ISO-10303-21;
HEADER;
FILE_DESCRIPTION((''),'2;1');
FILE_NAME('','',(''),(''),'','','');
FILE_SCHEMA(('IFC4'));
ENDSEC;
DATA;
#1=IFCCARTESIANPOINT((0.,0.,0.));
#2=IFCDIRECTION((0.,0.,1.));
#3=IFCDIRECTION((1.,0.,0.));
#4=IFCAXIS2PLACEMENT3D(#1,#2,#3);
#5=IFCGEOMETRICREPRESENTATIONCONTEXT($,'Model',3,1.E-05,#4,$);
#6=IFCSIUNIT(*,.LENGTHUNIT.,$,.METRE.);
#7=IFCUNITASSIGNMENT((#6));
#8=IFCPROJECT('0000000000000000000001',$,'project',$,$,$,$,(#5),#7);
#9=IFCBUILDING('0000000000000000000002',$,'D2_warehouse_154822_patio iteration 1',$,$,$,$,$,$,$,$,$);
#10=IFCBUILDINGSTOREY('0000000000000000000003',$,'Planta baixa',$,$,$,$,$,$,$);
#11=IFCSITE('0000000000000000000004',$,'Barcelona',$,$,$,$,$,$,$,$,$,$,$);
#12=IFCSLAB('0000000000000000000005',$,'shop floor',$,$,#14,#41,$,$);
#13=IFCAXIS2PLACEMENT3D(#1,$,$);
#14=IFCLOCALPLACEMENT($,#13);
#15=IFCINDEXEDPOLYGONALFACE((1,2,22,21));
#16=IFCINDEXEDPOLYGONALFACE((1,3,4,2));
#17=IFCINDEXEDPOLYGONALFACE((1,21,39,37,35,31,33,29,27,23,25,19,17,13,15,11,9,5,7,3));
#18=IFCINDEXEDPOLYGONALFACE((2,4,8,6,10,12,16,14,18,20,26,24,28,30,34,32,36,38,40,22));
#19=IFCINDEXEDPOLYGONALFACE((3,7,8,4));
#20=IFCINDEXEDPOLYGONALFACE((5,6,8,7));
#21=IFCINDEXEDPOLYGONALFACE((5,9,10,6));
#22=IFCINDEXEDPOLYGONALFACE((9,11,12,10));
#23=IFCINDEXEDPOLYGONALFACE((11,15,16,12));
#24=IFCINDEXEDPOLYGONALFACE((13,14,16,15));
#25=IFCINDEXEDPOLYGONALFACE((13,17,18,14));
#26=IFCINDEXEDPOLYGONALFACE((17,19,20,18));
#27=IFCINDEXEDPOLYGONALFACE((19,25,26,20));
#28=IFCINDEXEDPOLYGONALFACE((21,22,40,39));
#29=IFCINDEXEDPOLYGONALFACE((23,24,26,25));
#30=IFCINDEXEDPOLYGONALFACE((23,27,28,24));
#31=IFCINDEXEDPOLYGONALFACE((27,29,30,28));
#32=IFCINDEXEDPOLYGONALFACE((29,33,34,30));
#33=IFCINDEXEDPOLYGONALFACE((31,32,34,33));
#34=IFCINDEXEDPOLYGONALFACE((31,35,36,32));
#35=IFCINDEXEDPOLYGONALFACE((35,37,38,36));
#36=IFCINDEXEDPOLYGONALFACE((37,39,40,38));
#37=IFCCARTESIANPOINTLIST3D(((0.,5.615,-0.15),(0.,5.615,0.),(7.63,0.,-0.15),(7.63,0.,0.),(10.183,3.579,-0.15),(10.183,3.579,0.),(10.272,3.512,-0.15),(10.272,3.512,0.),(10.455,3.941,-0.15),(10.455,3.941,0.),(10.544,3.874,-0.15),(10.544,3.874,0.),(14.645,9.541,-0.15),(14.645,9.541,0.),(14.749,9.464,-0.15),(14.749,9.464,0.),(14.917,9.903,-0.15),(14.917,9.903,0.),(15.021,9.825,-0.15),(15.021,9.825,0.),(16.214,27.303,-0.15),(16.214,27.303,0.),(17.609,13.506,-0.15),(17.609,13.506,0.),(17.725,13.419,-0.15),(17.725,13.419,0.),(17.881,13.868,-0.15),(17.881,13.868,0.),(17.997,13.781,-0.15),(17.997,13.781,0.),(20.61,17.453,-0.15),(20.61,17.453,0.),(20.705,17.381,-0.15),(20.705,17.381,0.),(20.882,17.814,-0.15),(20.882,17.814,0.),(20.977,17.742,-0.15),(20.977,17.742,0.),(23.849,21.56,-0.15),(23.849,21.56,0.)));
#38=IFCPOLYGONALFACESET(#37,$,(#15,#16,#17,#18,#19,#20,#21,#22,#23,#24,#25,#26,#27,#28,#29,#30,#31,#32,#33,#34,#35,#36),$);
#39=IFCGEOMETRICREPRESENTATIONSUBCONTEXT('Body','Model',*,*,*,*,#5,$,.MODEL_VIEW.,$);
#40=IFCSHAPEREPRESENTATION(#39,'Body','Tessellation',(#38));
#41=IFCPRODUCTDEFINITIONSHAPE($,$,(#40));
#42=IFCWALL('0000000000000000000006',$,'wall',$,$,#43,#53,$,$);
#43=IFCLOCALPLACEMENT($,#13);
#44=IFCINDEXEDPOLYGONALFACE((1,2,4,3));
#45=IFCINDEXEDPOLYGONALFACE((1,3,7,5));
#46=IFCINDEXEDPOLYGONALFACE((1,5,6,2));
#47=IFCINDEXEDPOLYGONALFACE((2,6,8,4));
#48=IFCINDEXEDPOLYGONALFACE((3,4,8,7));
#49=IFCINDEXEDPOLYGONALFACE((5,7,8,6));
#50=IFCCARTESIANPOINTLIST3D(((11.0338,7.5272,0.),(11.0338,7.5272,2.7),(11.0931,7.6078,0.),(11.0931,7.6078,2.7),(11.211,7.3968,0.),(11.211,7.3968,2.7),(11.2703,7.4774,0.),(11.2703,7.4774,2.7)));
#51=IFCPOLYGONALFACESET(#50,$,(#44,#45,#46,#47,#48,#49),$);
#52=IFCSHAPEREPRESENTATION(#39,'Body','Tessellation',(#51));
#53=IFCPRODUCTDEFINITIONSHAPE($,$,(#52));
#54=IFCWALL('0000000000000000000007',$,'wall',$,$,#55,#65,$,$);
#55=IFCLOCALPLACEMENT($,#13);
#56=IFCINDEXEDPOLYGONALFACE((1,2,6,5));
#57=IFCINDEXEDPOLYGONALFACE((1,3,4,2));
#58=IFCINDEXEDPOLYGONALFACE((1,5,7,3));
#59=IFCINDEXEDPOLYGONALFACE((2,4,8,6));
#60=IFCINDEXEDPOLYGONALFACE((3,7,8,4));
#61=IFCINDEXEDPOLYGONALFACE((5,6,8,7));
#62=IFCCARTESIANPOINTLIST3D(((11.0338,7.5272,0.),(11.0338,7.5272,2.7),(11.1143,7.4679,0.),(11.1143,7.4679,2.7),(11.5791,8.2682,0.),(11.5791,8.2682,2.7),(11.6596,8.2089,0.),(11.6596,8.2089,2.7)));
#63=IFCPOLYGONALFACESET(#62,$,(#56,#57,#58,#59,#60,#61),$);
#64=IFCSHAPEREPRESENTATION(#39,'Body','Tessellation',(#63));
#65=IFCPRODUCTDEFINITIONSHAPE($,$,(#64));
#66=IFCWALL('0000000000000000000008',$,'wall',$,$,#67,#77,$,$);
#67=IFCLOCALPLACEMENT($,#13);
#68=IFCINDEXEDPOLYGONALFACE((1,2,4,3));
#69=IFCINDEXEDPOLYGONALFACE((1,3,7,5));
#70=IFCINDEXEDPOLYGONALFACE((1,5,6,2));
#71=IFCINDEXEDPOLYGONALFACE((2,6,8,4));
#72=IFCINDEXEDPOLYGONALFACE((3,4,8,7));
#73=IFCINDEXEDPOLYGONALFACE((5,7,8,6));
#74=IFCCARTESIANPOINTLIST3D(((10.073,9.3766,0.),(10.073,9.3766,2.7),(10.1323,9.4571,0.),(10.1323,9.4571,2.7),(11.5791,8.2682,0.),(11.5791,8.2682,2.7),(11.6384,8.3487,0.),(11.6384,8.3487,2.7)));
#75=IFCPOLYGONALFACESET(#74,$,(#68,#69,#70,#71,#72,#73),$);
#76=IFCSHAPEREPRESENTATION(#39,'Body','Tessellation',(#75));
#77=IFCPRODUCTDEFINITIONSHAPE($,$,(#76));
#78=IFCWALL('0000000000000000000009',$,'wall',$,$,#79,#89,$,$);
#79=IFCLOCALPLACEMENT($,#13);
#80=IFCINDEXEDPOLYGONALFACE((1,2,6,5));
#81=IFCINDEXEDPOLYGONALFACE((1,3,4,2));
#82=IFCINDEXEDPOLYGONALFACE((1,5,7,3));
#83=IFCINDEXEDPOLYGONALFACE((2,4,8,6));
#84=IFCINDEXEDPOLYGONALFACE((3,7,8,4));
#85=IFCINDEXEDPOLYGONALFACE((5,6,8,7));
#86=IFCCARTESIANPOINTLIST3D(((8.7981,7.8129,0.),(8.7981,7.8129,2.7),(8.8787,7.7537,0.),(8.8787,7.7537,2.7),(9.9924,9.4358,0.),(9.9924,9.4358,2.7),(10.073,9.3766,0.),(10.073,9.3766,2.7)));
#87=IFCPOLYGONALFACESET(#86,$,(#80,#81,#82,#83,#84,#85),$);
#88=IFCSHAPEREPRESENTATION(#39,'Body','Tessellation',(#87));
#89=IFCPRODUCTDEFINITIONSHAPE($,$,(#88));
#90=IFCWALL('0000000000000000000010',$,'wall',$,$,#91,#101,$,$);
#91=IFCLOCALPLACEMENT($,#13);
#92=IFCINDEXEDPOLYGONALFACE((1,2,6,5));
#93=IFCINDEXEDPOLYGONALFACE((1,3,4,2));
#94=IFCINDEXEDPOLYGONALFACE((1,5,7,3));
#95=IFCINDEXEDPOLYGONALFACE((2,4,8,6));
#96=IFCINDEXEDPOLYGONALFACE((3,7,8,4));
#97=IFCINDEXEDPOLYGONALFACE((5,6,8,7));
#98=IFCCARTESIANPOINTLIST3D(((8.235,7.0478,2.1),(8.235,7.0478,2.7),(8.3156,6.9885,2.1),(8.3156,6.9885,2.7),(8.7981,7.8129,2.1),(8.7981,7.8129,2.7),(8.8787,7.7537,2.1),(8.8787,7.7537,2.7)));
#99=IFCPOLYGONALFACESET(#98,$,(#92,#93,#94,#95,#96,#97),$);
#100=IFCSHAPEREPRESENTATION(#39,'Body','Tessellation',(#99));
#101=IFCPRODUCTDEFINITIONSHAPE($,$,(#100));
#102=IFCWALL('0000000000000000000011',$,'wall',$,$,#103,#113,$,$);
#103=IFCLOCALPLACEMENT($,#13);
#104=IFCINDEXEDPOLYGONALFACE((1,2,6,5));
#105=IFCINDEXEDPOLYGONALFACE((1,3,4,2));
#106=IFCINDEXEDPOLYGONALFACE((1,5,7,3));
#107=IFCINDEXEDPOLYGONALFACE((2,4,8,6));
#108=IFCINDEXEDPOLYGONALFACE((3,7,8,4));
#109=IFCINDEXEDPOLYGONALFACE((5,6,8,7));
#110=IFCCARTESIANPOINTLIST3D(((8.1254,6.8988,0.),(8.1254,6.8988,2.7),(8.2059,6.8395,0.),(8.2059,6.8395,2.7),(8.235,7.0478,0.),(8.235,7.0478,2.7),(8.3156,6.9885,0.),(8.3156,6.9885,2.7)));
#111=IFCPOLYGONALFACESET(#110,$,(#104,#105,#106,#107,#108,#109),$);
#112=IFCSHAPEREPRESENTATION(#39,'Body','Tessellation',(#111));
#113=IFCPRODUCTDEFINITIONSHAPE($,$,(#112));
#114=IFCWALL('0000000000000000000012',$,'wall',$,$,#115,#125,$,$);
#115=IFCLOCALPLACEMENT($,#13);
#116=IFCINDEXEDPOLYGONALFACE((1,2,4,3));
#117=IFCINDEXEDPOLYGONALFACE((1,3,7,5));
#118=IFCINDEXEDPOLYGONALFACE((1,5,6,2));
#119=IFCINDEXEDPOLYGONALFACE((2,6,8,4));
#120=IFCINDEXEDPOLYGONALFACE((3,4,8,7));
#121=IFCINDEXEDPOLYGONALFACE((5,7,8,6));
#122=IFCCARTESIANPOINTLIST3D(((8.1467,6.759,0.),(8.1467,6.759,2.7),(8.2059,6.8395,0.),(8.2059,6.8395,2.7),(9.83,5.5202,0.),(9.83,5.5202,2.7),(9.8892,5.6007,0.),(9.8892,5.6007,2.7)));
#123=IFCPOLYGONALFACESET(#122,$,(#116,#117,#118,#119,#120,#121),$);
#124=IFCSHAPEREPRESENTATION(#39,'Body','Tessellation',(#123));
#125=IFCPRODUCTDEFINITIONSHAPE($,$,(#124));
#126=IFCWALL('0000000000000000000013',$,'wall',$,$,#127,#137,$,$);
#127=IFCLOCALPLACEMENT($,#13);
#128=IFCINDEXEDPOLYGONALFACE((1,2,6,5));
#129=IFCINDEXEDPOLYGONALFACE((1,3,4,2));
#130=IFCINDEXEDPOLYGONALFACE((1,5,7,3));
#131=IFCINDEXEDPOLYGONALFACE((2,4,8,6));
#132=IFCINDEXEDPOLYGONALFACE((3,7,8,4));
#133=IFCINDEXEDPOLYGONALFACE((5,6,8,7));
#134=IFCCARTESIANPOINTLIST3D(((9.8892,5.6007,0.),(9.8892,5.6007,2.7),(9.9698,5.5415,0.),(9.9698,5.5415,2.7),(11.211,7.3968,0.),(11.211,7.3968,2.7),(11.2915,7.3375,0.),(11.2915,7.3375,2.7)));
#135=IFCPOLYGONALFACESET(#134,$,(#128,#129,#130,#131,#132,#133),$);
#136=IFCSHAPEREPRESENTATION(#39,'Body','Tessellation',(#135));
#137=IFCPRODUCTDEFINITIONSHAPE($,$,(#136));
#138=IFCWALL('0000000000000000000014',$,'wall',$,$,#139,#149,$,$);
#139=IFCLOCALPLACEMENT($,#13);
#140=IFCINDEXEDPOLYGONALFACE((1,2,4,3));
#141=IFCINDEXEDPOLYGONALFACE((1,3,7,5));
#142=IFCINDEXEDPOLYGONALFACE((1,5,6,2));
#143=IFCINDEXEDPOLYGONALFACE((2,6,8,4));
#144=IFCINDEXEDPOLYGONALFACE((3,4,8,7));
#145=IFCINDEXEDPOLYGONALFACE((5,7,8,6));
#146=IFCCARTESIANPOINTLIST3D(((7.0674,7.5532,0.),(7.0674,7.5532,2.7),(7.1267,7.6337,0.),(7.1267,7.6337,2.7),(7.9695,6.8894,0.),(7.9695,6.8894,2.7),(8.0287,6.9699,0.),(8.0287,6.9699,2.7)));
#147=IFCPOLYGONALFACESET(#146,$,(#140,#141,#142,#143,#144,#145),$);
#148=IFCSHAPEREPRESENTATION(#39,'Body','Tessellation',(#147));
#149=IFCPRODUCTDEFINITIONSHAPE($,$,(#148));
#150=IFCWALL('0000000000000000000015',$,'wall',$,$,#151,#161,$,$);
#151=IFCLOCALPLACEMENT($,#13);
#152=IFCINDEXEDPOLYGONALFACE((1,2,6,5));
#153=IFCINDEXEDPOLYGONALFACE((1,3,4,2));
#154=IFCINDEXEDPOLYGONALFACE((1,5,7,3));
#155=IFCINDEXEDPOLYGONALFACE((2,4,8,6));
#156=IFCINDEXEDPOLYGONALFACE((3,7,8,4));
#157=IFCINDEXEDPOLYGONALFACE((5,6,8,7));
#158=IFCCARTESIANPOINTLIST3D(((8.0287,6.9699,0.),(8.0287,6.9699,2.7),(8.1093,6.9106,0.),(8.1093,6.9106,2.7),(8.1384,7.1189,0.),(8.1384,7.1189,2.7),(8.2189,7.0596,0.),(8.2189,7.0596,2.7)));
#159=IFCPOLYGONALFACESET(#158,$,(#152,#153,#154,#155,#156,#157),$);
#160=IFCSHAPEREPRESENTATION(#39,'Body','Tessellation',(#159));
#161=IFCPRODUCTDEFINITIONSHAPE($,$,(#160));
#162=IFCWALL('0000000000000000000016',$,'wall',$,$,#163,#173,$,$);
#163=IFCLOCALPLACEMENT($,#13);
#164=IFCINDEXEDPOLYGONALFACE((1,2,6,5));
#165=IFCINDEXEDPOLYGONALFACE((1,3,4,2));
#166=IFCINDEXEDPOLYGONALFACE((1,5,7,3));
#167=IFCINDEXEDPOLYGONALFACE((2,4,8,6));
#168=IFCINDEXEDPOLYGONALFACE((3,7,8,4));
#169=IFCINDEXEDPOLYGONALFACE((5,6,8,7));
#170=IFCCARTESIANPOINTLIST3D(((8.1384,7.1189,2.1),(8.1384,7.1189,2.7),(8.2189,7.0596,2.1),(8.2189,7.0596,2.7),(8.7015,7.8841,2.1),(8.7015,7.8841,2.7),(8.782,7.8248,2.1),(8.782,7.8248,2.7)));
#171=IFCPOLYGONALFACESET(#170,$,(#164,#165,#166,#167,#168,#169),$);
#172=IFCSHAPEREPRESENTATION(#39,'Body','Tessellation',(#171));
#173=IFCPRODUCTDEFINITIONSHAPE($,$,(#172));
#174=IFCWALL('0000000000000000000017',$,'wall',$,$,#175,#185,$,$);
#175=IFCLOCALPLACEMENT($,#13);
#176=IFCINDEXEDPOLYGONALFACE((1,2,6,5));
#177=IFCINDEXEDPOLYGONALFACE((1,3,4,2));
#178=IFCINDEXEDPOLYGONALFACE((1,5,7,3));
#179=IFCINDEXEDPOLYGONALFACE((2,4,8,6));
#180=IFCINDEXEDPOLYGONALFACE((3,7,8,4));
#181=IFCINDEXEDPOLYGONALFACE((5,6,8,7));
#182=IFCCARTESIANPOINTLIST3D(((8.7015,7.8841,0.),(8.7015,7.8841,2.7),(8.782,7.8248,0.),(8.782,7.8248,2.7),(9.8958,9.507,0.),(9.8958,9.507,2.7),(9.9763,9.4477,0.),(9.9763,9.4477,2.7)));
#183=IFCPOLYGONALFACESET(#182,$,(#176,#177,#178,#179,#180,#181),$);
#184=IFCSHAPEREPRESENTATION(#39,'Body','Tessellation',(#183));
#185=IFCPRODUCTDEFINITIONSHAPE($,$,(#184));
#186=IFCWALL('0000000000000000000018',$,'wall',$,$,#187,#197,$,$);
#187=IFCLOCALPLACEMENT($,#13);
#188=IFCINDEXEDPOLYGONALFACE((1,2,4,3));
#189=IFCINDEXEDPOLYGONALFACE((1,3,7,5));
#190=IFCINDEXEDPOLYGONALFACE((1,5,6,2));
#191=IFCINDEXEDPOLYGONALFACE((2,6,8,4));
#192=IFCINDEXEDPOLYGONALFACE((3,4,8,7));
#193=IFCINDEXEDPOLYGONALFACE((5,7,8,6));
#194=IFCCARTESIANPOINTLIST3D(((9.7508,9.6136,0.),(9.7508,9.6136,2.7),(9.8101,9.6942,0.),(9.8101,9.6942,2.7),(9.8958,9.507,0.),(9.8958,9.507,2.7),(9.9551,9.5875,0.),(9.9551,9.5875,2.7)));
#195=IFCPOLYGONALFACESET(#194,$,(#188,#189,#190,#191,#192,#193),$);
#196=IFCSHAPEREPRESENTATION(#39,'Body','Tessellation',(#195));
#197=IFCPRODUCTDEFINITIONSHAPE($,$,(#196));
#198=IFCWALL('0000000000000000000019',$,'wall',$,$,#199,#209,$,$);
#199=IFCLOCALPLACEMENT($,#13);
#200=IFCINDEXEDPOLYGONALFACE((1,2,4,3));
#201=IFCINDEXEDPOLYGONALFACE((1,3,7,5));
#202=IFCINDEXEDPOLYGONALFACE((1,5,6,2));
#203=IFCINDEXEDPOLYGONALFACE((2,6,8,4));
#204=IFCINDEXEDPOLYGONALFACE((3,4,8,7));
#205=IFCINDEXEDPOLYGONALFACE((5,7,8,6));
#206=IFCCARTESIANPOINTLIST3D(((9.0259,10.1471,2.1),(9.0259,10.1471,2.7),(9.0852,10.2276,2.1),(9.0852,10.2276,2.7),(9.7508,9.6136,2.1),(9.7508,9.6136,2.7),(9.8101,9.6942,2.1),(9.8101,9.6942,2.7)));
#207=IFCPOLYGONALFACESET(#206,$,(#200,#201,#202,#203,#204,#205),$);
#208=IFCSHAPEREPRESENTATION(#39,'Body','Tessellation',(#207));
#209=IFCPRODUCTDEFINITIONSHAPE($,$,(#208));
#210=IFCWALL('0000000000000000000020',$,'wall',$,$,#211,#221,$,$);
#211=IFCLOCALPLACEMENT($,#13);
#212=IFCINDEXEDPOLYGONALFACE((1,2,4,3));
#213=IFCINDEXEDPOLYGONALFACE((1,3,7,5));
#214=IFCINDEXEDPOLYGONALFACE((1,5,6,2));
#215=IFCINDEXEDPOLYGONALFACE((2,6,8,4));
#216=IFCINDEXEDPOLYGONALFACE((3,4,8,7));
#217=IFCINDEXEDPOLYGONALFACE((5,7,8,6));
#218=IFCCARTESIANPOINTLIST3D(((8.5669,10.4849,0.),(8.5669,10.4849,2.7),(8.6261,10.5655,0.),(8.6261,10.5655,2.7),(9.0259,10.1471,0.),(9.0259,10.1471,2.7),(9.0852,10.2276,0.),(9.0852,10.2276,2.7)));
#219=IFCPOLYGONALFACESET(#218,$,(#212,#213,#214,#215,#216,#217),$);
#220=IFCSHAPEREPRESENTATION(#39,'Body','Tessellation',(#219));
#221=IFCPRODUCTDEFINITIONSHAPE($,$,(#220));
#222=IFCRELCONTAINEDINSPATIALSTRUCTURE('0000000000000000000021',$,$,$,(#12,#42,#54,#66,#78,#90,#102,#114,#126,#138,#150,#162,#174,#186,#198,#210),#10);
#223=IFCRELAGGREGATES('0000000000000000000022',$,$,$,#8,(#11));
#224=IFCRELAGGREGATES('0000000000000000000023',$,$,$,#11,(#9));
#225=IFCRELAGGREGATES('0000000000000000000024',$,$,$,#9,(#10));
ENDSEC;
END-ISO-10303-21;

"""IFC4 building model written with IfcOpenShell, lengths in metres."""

from ifc_helpers import new_model, si_unit, frame, origin, origin_with_axes, place, context, subcontext, project, spatial, polyline, outline, extrude, element, save


model = new_model("IFC4")

# Units and contexts
model_context = context("Model", 3, precision=1e-05, world=origin_with_axes())
body_context = subcontext(model_context, "Body", "Model", "MODEL_VIEW")
ifc_project = project(units=[si_unit("LENGTHUNIT", "METRE")], contexts=[model_context])

# Site, building, storey
site = spatial("IfcSite", under=ifc_project, Name="Barcelona")
building = spatial("IfcBuilding", under=site, Name="D2_warehouse_154822_patio iteration 1")
storey = spatial("IfcBuildingStorey", under=building, Name="Planta baixa")

# Slab
slab_placement = place(None, origin_with_axes())
element("IfcSlab", 1, at=slab_placement, inside=storey, Name="shop floor", context=body_context, shape_type="SweptSolid", body=[
    extrude(outline(polyline([(0.0, 5.615), (16.214, 27.303), (23.849, 21.56), (20.977, 17.742), (20.882, 17.814), (20.61, 17.453), (20.705, 17.381), (17.997, 13.781), (17.881, 13.868), (17.609, 13.506), (17.725, 13.419), (15.021, 9.825), (14.917, 9.903), (14.645, 9.541), (14.749, 9.464), (10.544, 3.874), (10.455, 3.941), (10.183, 3.579), (10.272, 3.512), (7.63, 0.0), (0.0, 5.615)])), frame((0.0, 0.0, -0.15)), (0.0, 0.0, 1.0), 0.15),
])

# Walls
wall_1_placement = place(None, origin_with_axes())
element("IfcWall", 2, at=wall_1_placement, inside=storey, Name="wall", context=body_context, shape_type="SweptSolid", body=[
    extrude(outline(polyline([(11.211, 7.3968), (11.0338, 7.5272), (11.0931, 7.6078), (11.2703, 7.4774), (11.211, 7.3968)])), origin(), (0.0, 0.0, 1.0), 2.7),
])
wall_2_placement = place(None, origin_with_axes())
element("IfcWall", 3, at=wall_2_placement, inside=storey, Name="wall", context=body_context, shape_type="SweptSolid", body=[
    extrude(outline(polyline([(11.0338, 7.5272), (11.5791, 8.2682), (11.6596, 8.2089), (11.1143, 7.4679), (11.0338, 7.5272)])), origin(), (0.0, 0.0, 1.0), 2.7),
])
wall_3_placement = place(None, origin_with_axes())
element("IfcWall", 4, at=wall_3_placement, inside=storey, Name="wall", context=body_context, shape_type="SweptSolid", body=[
    extrude(outline(polyline([(11.5791, 8.2682), (10.073, 9.3766), (10.1323, 9.4571), (11.6384, 8.3487), (11.5791, 8.2682)])), origin(), (0.0, 0.0, 1.0), 2.7),
])
wall_4_placement = place(None, origin_with_axes())
element("IfcWall", 5, at=wall_4_placement, inside=storey, Name="wall", context=body_context, shape_type="SweptSolid", body=[
    extrude(outline(polyline([(10.073, 9.3766), (8.8787, 7.7537), (8.7981, 7.8129), (9.9924, 9.4358), (10.073, 9.3766)])), origin(), (0.0, 0.0, 1.0), 2.7),
])
wall_5_placement = place(None, origin_with_axes())
element("IfcWall", 6, at=wall_5_placement, inside=storey, Name="wall", context=body_context, shape_type="SweptSolid", body=[
    extrude(outline(polyline([(8.8787, 7.7537), (8.3156, 6.9885), (8.235, 7.0478), (8.7981, 7.8129), (8.8787, 7.7537)])), frame((0.0, 0.0, 2.1)), (0.0, 0.0, 1.0), 0.6),
])
wall_6_placement = place(None, origin_with_axes())
element("IfcWall", 7, at=wall_6_placement, inside=storey, Name="wall", context=body_context, shape_type="SweptSolid", body=[
    extrude(outline(polyline([(8.3156, 6.9885), (8.2059, 6.8395), (8.1254, 6.8988), (8.235, 7.0478), (8.3156, 6.9885)])), origin(), (0.0, 0.0, 1.0), 2.7),
])
wall_7_placement = place(None, origin_with_axes())
element("IfcWall", 8, at=wall_7_placement, inside=storey, Name="wall", context=body_context, shape_type="SweptSolid", body=[
    extrude(outline(polyline([(8.2059, 6.8395), (9.8892, 5.6007), (9.83, 5.5202), (8.1467, 6.759), (8.2059, 6.8395)])), origin(), (0.0, 0.0, 1.0), 2.7),
])
wall_8_placement = place(None, origin_with_axes())
element("IfcWall", 9, at=wall_8_placement, inside=storey, Name="wall", context=body_context, shape_type="SweptSolid", body=[
    extrude(outline(polyline([(9.8892, 5.6007), (11.211, 7.3968), (11.2915, 7.3375), (9.9698, 5.5415), (9.8892, 5.6007)])), origin(), (0.0, 0.0, 1.0), 2.7),
])
wall_9_placement = place(None, origin_with_axes())
element("IfcWall", 10, at=wall_9_placement, inside=storey, Name="wall", context=body_context, shape_type="SweptSolid", body=[
    extrude(outline(polyline([(7.1267, 7.6337), (8.0287, 6.9699), (7.9695, 6.8894), (7.0674, 7.5532), (7.1267, 7.6337)])), origin(), (0.0, 0.0, 1.0), 2.7),
])
wall_10_placement = place(None, origin_with_axes())
element("IfcWall", 11, at=wall_10_placement, inside=storey, Name="wall", context=body_context, shape_type="SweptSolid", body=[
    extrude(outline(polyline([(8.0287, 6.9699), (8.1384, 7.1189), (8.2189, 7.0596), (8.1093, 6.9106), (8.0287, 6.9699)])), origin(), (0.0, 0.0, 1.0), 2.7),
])
wall_11_placement = place(None, origin_with_axes())
element("IfcWall", 12, at=wall_11_placement, inside=storey, Name="wall", context=body_context, shape_type="SweptSolid", body=[
    extrude(outline(polyline([(8.1384, 7.1189), (8.7015, 7.8841), (8.782, 7.8248), (8.2189, 7.0596), (8.1384, 7.1189)])), frame((0.0, 0.0, 2.1)), (0.0, 0.0, 1.0), 0.6),
])
wall_12_placement = place(None, origin_with_axes())
element("IfcWall", 13, at=wall_12_placement, inside=storey, Name="wall", context=body_context, shape_type="SweptSolid", body=[
    extrude(outline(polyline([(8.7015, 7.8841), (9.8958, 9.507), (9.9763, 9.4477), (8.782, 7.8248), (8.7015, 7.8841)])), origin(), (0.0, 0.0, 1.0), 2.7),
])
wall_13_placement = place(None, origin_with_axes())
element("IfcWall", 14, at=wall_13_placement, inside=storey, Name="wall", context=body_context, shape_type="SweptSolid", body=[
    extrude(outline(polyline([(9.8958, 9.507), (9.7508, 9.6136), (9.8101, 9.6942), (9.9551, 9.5875), (9.8958, 9.507)])), origin(), (0.0, 0.0, 1.0), 2.7),
])
wall_14_placement = place(None, origin_with_axes())
element("IfcWall", 15, at=wall_14_placement, inside=storey, Name="wall", context=body_context, shape_type="SweptSolid", body=[
    extrude(outline(polyline([(9.7508, 9.6136), (9.0259, 10.1471), (9.0852, 10.2276), (9.8101, 9.6942), (9.7508, 9.6136)])), frame((0.0, 0.0, 2.1)), (0.0, 0.0, 1.0), 0.6),
])
wall_15_placement = place(None, origin_with_axes())
element("IfcWall", 16, at=wall_15_placement, inside=storey, Name="wall", context=body_context, shape_type="SweptSolid", body=[
    extrude(outline(polyline([(9.0259, 10.1471), (8.5669, 10.4849), (8.6261, 10.5655), (9.0852, 10.2276), (9.0259, 10.1471)])), origin(), (0.0, 0.0, 1.0), 2.7),
])

save(model, "model.ifc")
